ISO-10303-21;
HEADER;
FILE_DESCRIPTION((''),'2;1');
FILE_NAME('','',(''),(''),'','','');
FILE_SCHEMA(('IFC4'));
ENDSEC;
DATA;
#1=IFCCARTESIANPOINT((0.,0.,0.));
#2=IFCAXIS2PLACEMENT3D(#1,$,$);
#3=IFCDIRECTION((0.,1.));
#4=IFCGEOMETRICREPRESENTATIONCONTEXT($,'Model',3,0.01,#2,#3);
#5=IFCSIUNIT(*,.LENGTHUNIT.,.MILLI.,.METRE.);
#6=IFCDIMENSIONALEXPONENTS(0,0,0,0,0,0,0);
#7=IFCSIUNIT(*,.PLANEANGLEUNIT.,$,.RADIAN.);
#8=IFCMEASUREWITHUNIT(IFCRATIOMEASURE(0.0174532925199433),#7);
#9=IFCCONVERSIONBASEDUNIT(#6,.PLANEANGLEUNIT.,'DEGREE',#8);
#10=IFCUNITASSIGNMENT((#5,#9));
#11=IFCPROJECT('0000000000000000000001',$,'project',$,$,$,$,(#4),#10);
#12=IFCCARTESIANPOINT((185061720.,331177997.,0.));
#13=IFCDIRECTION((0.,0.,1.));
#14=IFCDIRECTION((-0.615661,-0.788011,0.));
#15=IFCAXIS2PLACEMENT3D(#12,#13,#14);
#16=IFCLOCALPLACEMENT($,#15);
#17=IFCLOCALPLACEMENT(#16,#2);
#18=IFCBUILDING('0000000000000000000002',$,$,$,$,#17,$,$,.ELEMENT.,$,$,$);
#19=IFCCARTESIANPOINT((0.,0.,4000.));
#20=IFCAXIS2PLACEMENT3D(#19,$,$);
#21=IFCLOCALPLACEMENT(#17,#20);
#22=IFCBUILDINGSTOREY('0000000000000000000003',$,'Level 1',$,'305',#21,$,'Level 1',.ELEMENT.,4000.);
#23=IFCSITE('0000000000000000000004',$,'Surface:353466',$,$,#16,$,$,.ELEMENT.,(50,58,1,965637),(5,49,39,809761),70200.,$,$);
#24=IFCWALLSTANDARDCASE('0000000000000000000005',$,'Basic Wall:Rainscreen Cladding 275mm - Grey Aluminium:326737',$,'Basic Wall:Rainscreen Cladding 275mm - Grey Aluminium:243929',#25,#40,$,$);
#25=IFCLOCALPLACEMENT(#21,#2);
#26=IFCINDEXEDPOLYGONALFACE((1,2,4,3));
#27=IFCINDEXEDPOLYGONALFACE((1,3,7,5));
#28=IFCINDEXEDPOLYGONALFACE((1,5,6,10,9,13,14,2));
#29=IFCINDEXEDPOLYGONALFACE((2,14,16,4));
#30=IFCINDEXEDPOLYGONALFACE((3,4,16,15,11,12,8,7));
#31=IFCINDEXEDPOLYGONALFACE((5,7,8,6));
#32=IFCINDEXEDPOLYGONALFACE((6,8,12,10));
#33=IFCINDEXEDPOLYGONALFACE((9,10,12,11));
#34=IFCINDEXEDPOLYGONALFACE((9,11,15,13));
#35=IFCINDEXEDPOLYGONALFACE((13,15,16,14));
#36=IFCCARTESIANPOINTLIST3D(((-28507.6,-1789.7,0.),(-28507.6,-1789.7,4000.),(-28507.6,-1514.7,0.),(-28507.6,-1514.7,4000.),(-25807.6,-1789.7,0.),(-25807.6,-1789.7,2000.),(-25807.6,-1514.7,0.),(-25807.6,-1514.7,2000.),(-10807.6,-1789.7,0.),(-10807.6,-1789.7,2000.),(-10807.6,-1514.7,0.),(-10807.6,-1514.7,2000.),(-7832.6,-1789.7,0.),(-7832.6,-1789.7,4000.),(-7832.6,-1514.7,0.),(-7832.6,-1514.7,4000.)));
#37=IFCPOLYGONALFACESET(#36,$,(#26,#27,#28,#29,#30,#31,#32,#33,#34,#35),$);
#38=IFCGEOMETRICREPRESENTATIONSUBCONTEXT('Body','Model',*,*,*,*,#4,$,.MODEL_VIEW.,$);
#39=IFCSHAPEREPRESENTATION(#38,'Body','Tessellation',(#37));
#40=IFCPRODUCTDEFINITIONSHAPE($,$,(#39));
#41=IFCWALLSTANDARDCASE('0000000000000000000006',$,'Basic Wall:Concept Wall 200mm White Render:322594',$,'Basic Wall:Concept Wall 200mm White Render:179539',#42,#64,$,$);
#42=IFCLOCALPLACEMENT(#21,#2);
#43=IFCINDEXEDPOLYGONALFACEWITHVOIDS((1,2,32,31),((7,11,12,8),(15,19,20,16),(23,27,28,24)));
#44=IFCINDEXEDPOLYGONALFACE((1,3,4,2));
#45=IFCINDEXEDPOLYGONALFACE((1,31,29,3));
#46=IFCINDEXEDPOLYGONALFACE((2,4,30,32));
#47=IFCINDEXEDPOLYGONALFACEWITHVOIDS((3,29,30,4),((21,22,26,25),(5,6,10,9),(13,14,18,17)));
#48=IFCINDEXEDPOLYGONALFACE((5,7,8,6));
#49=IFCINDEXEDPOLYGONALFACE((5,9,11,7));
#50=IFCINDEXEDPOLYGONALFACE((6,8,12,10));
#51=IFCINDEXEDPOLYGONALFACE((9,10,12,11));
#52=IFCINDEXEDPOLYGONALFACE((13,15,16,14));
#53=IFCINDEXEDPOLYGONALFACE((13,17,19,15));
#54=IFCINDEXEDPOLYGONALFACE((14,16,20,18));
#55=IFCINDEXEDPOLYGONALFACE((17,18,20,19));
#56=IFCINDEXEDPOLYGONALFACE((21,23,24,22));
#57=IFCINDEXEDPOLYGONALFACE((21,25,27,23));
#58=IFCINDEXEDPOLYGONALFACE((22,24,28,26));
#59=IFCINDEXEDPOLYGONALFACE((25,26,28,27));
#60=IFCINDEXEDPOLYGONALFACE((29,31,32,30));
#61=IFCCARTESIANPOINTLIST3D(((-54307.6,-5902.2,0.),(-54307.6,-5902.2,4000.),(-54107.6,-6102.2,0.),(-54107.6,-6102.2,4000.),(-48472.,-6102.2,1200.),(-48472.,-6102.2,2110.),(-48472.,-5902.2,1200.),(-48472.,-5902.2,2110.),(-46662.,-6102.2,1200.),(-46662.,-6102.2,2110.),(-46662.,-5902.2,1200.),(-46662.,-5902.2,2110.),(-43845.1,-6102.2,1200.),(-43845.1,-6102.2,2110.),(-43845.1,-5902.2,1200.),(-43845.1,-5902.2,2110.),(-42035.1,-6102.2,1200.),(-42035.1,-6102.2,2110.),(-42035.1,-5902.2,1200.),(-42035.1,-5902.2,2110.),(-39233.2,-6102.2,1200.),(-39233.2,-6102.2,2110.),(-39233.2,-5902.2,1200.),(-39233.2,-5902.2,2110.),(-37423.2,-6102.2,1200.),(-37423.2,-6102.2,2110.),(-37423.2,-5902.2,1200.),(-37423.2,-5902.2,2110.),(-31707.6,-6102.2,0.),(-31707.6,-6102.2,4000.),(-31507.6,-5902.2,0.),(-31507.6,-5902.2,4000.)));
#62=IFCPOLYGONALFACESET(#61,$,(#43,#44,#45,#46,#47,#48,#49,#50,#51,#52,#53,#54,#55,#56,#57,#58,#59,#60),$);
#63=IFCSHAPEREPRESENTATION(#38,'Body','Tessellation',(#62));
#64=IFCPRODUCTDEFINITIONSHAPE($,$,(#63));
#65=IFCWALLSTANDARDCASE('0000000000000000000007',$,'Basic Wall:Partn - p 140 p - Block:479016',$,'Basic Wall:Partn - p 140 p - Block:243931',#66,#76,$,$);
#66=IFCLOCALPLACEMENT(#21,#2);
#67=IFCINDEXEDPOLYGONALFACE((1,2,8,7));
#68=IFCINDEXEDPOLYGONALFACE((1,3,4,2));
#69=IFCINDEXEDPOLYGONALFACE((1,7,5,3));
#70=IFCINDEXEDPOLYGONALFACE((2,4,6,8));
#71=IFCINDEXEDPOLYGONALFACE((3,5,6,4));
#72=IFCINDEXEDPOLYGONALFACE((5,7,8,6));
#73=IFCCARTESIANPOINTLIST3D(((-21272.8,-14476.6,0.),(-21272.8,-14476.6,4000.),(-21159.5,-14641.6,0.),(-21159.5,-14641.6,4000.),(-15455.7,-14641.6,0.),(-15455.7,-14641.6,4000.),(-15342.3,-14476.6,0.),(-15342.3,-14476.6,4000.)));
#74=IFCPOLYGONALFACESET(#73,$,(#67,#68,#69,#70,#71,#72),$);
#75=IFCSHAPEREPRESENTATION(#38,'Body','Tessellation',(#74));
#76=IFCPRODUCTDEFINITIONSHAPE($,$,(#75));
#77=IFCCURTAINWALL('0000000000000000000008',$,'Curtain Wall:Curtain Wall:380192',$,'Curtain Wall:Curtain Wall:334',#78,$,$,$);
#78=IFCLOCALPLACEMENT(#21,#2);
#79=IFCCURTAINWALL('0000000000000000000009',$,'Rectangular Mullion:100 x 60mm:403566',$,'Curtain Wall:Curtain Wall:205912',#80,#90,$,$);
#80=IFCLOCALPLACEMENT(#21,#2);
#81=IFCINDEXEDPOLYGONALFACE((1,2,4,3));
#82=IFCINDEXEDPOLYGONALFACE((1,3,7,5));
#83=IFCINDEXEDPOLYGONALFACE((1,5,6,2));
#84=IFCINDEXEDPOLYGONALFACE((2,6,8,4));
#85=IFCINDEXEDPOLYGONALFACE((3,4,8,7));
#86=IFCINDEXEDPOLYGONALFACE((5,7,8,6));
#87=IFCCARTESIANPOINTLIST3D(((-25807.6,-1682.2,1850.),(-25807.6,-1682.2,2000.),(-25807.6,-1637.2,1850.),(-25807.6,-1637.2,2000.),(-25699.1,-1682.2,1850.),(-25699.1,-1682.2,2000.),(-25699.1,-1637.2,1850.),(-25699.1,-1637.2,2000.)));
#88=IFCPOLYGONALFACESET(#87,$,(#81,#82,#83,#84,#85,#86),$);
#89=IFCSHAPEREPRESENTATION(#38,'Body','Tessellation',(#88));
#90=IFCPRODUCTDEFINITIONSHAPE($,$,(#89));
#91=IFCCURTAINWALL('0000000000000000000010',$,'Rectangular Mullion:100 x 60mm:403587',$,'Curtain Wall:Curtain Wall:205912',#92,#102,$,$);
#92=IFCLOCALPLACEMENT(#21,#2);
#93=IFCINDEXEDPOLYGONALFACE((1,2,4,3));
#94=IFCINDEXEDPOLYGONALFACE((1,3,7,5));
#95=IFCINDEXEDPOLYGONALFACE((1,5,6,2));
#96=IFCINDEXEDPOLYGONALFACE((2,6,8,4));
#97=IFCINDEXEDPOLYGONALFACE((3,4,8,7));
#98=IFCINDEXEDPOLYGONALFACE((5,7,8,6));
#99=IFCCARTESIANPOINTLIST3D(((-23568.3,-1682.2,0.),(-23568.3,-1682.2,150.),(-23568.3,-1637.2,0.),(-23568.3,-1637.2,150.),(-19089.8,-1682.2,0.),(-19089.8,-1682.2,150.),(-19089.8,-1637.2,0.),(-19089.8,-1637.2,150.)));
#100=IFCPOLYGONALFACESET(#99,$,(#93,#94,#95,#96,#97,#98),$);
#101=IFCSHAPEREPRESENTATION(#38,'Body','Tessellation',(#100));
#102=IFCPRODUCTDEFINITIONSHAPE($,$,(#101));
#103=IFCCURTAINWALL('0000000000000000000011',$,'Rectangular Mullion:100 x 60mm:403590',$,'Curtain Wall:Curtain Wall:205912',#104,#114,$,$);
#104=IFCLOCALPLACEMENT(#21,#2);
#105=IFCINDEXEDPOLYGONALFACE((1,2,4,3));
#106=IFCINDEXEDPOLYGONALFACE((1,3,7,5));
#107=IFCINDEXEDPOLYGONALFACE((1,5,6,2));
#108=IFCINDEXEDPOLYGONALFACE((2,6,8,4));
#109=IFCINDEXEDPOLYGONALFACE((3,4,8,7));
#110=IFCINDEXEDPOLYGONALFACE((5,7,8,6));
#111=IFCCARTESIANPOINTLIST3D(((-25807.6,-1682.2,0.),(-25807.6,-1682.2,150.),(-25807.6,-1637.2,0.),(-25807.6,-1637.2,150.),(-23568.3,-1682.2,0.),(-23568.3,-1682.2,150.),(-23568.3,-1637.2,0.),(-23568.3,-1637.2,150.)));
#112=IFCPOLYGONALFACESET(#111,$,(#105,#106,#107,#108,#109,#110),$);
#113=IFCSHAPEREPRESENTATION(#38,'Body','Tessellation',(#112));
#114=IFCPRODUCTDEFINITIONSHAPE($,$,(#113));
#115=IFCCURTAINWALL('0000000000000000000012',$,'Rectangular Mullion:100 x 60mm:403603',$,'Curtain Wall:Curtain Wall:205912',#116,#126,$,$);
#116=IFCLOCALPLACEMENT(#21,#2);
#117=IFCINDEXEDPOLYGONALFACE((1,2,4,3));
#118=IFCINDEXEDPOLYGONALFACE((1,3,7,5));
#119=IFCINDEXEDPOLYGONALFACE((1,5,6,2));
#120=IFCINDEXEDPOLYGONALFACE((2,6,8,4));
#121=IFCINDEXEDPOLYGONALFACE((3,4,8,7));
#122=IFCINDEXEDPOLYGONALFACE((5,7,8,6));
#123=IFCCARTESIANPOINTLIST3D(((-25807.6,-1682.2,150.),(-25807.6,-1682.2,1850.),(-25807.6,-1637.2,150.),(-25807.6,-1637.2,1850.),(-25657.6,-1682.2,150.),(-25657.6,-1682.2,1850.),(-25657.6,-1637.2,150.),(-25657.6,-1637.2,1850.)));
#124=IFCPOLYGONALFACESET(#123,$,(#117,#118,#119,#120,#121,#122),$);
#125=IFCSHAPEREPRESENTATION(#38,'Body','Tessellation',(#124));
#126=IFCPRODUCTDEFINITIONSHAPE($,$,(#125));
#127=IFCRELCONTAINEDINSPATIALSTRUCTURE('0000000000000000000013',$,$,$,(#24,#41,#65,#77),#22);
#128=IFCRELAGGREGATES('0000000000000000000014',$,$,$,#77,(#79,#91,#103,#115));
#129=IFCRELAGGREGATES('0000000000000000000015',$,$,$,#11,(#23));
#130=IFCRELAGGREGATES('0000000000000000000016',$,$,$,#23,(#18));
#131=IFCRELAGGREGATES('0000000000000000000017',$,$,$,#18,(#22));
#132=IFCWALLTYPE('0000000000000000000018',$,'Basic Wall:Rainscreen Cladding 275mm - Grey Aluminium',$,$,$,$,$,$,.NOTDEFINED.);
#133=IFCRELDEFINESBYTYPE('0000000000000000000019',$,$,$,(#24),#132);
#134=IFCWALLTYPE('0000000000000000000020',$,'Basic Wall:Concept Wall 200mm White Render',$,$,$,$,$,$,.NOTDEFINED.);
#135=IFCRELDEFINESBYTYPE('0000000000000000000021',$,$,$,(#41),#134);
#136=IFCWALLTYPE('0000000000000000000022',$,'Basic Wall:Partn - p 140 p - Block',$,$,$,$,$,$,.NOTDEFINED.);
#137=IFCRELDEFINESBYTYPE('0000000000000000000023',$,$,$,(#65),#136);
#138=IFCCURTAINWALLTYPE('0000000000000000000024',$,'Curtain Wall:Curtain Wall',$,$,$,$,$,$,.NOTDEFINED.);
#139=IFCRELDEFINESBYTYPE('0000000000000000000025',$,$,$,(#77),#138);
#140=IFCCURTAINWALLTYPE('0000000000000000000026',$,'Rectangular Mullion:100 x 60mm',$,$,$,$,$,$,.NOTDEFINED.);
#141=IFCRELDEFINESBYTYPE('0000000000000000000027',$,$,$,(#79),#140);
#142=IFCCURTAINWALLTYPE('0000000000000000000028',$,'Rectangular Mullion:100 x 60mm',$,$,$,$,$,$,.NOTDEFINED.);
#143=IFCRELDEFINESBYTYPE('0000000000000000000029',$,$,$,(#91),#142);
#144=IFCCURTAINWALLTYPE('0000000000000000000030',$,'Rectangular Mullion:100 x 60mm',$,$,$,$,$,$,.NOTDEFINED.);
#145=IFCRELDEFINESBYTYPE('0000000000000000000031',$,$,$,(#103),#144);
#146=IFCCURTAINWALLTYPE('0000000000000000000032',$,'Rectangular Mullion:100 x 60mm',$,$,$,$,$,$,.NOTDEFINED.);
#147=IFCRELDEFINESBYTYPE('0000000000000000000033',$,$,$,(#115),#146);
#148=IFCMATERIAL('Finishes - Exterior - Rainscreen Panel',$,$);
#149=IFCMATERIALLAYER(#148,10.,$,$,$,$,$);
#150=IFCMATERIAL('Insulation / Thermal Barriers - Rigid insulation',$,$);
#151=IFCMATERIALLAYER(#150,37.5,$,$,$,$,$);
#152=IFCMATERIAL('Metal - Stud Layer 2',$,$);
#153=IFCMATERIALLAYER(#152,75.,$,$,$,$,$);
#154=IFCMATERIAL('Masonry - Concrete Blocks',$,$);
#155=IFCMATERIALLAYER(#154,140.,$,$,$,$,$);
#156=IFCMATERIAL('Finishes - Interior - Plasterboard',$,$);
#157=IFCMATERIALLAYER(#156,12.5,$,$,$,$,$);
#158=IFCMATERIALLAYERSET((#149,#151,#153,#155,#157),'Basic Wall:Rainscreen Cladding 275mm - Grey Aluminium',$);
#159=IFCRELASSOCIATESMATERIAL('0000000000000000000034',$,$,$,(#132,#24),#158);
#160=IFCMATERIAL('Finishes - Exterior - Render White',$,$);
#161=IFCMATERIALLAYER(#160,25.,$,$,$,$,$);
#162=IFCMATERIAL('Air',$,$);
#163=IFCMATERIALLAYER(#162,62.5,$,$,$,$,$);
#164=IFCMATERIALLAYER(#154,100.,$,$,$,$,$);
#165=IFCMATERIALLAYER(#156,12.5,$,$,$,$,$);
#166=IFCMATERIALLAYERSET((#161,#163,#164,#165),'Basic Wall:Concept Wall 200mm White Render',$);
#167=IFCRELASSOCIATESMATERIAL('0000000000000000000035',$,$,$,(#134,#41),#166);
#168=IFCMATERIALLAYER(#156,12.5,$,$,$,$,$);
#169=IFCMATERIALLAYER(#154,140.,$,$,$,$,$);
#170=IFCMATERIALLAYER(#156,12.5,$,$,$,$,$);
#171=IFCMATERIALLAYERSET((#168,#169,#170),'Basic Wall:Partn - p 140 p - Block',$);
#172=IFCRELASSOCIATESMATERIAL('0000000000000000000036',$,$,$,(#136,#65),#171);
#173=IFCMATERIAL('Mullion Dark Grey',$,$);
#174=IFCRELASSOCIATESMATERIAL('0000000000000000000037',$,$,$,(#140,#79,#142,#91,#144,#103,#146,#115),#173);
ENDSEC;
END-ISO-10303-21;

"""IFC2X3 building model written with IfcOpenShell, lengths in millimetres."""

from ifc_helpers import new_model, entity, si_unit, converted_unit, direction, frame, frame_2d, origin, origin_2d_with_axis, place, context, subcontext, project, spatial, polyline, rectangle, outline, extrude, clip, halfspace, source, transform, mapped, material, layer, layer_set, layer_usage, type_object, type_shapes, element, aggregate, save


model = new_model("IFC2X3")

# Units and contexts
model_context = context("Model", 3, precision=0.01, world=origin(), true_north=direction((0.0, 1.0)))
body_context = subcontext(model_context, "Body", "Model", "MODEL_VIEW")
ifc_project = project(units=[si_unit("LENGTHUNIT", "METRE", prefix="MILLI"), converted_unit("PLANEANGLEUNIT", "DEGREE", entity("IfcRatioMeasure", 0.0174532925199433), si_unit("PLANEANGLEUNIT", "RADIAN"), dimensions=[0, 0, 0, 0, 0, 0, 0])], contexts=[model_context])

# Site, building, storey
site_placement = place(None, frame((185061720.0, 331177997.0, 0.0), z_axis=(0.0, 0.0, 1.0), x_axis=(-0.615661, -0.788011, 0.0)))
site = spatial("IfcSite", under=ifc_project, at=site_placement, Name="Surface:353466", CompositionType="ELEMENT", RefLatitude=(50, 58, 1, 965637), RefLongitude=(5, 49, 39, 809761), RefElevation=70200.0)
building_placement = place(site_placement, origin())
building = spatial("IfcBuilding", under=site, at=building_placement, CompositionType="ELEMENT")
storey_placement = place(building_placement, frame((0.0, 0.0, 4000.0)))
storey = spatial("IfcBuildingStorey", under=building, at=storey_placement, Name="Level 1", ObjectType="305", LongName="Level 1", CompositionType="ELEMENT", Elevation=4000.0)

# Wall, opening
ifc_material_1 = material(Name="Finishes - Exterior - Rainscreen Panel")
ifc_layer_1 = layer(ifc_material_1, 10.0)
ifc_material_2 = material(Name="Insulation / Thermal Barriers - Rigid insulation")
ifc_layer_2 = layer(ifc_material_2, 37.5)
ifc_material_3 = material(Name="Metal - Stud Layer 2")
ifc_layer_3 = layer(ifc_material_3, 75.0)
ifc_material_4 = material(Name="Masonry - Concrete Blocks")
ifc_layer_4 = layer(ifc_material_4, 140.0)
ifc_material_5 = material(Name="Finishes - Interior - Plasterboard")
ifc_layer_5 = layer(ifc_material_5, 12.5)
ifc_layer_set_1 = layer_set([ifc_layer_1, ifc_layer_2, ifc_layer_3, ifc_layer_4, ifc_layer_5], Name="Basic Wall:Rainscreen Cladding 275mm - Grey Aluminium")
ifc_layer_usage_1 = layer_usage(ifc_layer_set_1, "AXIS2", "NEGATIVE", 137.5)
wall_type_1 = type_object("IfcWallType", Name="Basic Wall:Rainscreen Cladding 275mm - Grey Aluminium", PredefinedType="NOTDEFINED", material=ifc_layer_set_1)
wall_1_placement = place(storey_placement, frame((-28507.6, -1652.2, 0.0)))
wall_1 = element("IfcWallStandardCase", 1, at=wall_1_placement, inside=storey, type_object=wall_type_1, material=ifc_layer_usage_1, Name="Basic Wall:Rainscreen Cladding 275mm - Grey Aluminium:326737", ObjectType="Basic Wall:Rainscreen Cladding 275mm - Grey Aluminium:243929", context=body_context, shape_type="Clipping", body=[
    clip(extrude(rectangle(XDim=20675.0, YDim=275.0, at=frame_2d((10337.5, 0.0), x_axis=(-1.0, 0.0))), origin(), (0.0, 0.0, 1.0), 4000.0), halfspace(frame((0.0, 0.0, -4000.0)), True)),
])
opening_1_placement = place(wall_1_placement, origin())
element("IfcOpeningElement", 2, at=opening_1_placement, cuts=wall_1, ObjectType="Opening", context=body_context, shape_type="SweptSolid", body=[
    extrude(rectangle(XDim=2000.0, YDim=15000.0, at=origin_2d_with_axis()), frame((10200.0, -289.9, 1000.0), z_axis=(0.0, 1.0, 0.0), x_axis=(0.0, 0.0, 1.0)), (0.0, 0.0, 1.0), 579.8),
])

# Wall, openings
ifc_material_6 = material(Name="Finishes - Exterior - Render White")
ifc_layer_6 = layer(ifc_material_6, 25.0)
ifc_material_7 = material(Name="Air")
ifc_layer_7 = layer(ifc_material_7, 62.5)
ifc_layer_8 = layer(ifc_material_4, 100.0)
ifc_layer_9 = layer(ifc_material_5, 12.5)
ifc_layer_set_2 = layer_set([ifc_layer_6, ifc_layer_7, ifc_layer_8, ifc_layer_9], Name="Basic Wall:Concept Wall 200mm White Render")
ifc_layer_usage_2 = layer_usage(ifc_layer_set_2, "AXIS2", "POSITIVE", -100.0)
wall_type_2 = type_object("IfcWallType", Name="Basic Wall:Concept Wall 200mm White Render", PredefinedType="NOTDEFINED", material=ifc_layer_set_2)
wall_2_placement = place(storey_placement, frame((-31507.6, -6002.2, 0.0), z_axis=(0.0, 0.0, 1.0), x_axis=(-1.0, 0.0, 0.0)))
wall_2 = element("IfcWallStandardCase", 3, at=wall_2_placement, inside=storey, type_object=wall_type_2, material=ifc_layer_usage_2, Name="Basic Wall:Concept Wall 200mm White Render:322594", ObjectType="Basic Wall:Concept Wall 200mm White Render:179539", context=body_context, shape_type="Clipping", body=[
    clip(extrude(outline(polyline([(22800.0, -100.0), (22600.0, 100.0), (13722.5, 100.0), (13557.5, 100.0), (5162.5, 100.0), (4997.5, 100.0), (200.0, 100.0), (0.0, -100.0), (22800.0, -100.0)])), origin(), (0.0, 0.0, 1.0), 4000.0), halfspace(frame((0.0, 0.0, -4000.0)), True)),
])
opening_2_placement = place(wall_2_placement, origin())
element("IfcOpeningElement", 4, at=opening_2_placement, cuts=wall_2, ObjectType="Opening", context=body_context, shape_type="SweptSolid", body=[
    extrude(rectangle(XDim=910.0, YDim=1810.0, at=frame_2d((0.0, 0.0), x_axis=(1.0, 0.0))), frame((11432.5, -1424.0, 1655.0), z_axis=(0.0, 1.0, 0.0), x_axis=(0.0, 0.0, -1.0)), (0.0, 0.0, 1.0), 3048.0),
])
opening_3_placement = place(wall_2_placement, origin())
element("IfcOpeningElement", 5, at=opening_3_placement, cuts=wall_2, ObjectType="Opening", context=body_context, shape_type="SweptSolid", body=[
    extrude(rectangle(XDim=910.0, YDim=1810.0, at=frame_2d((0.0, 0.0), x_axis=(1.0, 0.0))), frame((16059.4, -1424.0, 1655.0), z_axis=(0.0, 1.0, 0.0), x_axis=(0.0, 0.0, -1.0)), (0.0, 0.0, 1.0), 3048.0),
])
opening_4_placement = place(wall_2_placement, origin())
element("IfcOpeningElement", 6, at=opening_4_placement, cuts=wall_2, ObjectType="Opening", context=body_context, shape_type="SweptSolid", body=[
    extrude(rectangle(XDim=910.0, YDim=1810.0, at=frame_2d((0.0, 0.0), x_axis=(1.0, 0.0))), frame((6820.6, -1424.0, 1655.0), z_axis=(0.0, 1.0, 0.0), x_axis=(0.0, 0.0, -1.0)), (0.0, 0.0, 1.0), 3048.0),
])
opening_5_placement = place(wall_2_placement, frame((12337.5, 100.0, 1200.0)))
element("IfcOpeningElement", 7, at=opening_5_placement, cuts=wall_2, ObjectType="Opening", context=body_context, shape_type="SweptSolid", body=[
    extrude(rectangle(XDim=910.0, YDim=1810.0, at=frame_2d((455.0, 905.0), x_axis=(-1.0, 0.0))), frame((0.0, 0.0, 0.0), z_axis=(0.0, -1.0, 0.0), x_axis=(0.0, 0.0, 1.0)), (0.0, 0.0, 1.0), 200.0),
])
opening_6_placement = place(wall_2_placement, frame((16964.4, 100.0, 1200.0)))
element("IfcOpeningElement", 8, at=opening_6_placement, cuts=wall_2, ObjectType="Opening", context=body_context, shape_type="SweptSolid", body=[
    extrude(rectangle(XDim=910.0, YDim=1810.0, at=frame_2d((455.0, 905.0), x_axis=(-1.0, 0.0))), frame((0.0, 0.0, 0.0), z_axis=(0.0, -1.0, 0.0), x_axis=(0.0, 0.0, 1.0)), (0.0, 0.0, 1.0), 200.0),
])
opening_7_placement = place(wall_2_placement, frame((7725.6, 100.0, 1200.0)))
element("IfcOpeningElement", 9, at=opening_7_placement, cuts=wall_2, ObjectType="Opening", context=body_context, shape_type="SweptSolid", body=[
    extrude(rectangle(XDim=910.0, YDim=1810.0, at=frame_2d((455.0, 905.0), x_axis=(-1.0, 0.0))), frame((0.0, 0.0, 0.0), z_axis=(0.0, -1.0, 0.0), x_axis=(0.0, 0.0, 1.0)), (0.0, 0.0, 1.0), 200.0),
])

# Wall
ifc_layer_10 = layer(ifc_material_5, 12.5)
ifc_layer_11 = layer(ifc_material_4, 140.0)
ifc_layer_12 = layer(ifc_material_5, 12.5)
ifc_layer_set_3 = layer_set([ifc_layer_10, ifc_layer_11, ifc_layer_12], Name="Basic Wall:Partn - p 140 p - Block")
ifc_layer_usage_3 = layer_usage(ifc_layer_set_3, "AXIS2", "NEGATIVE", 82.5)
wall_type_3 = type_object("IfcWallType", Name="Basic Wall:Partn - p 140 p - Block", PredefinedType="NOTDEFINED", material=ifc_layer_set_3)
wall_3_placement = place(storey_placement, frame((-21272.8, -14559.1, 0.0)))
element("IfcWallStandardCase", 10, at=wall_3_placement, inside=storey, type_object=wall_type_3, material=ifc_layer_usage_3, Name="Basic Wall:Partn - p 140 p - Block:479016", ObjectType="Basic Wall:Partn - p 140 p - Block:243931", context=body_context, shape_type="Clipping", body=[
    clip(extrude(outline(polyline([(5817.2, -82.5), (5930.5, 82.5), (5778.8, 82.5), (3047.7, 82.5), (2882.7, 82.5), (151.6, 82.5), (0.0, 82.5), (113.3, -82.5), (5817.2, -82.5)])), origin(), (0.0, 0.0, 1.0), 4000.0), halfspace(origin(), True)),
])

# Curtain walls
curtain_wall_type_1 = type_object("IfcCurtainWallType", Name="Curtain Wall:Curtain Wall", PredefinedType="NOTDEFINED")
curtain_wall_1_placement = place(storey_placement, frame((0.0, 0.0, -4000.0)))
curtain_wall_1 = element("IfcCurtainWall", 11, at=curtain_wall_1_placement, inside=storey, type_object=curtain_wall_type_1, Name="Curtain Wall:Curtain Wall:380192", ObjectType="Curtain Wall:Curtain Wall:334")
ifc_material_8 = material(Name="Mullion Dark Grey")
curtain_wall_type_2 = type_object("IfcCurtainWallType", Name="Rectangular Mullion:100 x 60mm", PredefinedType="NOTDEFINED", material=ifc_material_8)
shared_shape_1 = source(origin(), body_context, "Body", "SweptSolid", [
    extrude(rectangle(XDim=45.0, YDim=150.0, at=frame_2d((0.0, 0.0), x_axis=(1.0, 0.0))), frame((-75.0, 7.5, -108.5), z_axis=(0.0, 0.0, 1.0), x_axis=(0.0, -1.0, 0.0)), (0.0, 0.0, 1.0), 108.5),
])
type_shapes(curtain_wall_type_2, [shared_shape_1])
curtain_wall_2_placement = place(storey_placement, frame((-25699.1, -1652.2, 2000.0), z_axis=(1.0, 0.0, 0.0), x_axis=(0.0, 0.0, 1.0)))
curtain_wall_2 = element("IfcCurtainWall", 12, at=curtain_wall_2_placement, type_object=curtain_wall_type_2, material=ifc_material_8, Name="Rectangular Mullion:100 x 60mm:403566", ObjectType="Curtain Wall:Curtain Wall:205912", context=body_context, shape_type="MappedRepresentation", body=[
    mapped(shared_shape_1, transform((0.0, 0.0, 0.0), scale=1.0)),
])
curtain_wall_type_3 = type_object("IfcCurtainWallType", Name="Rectangular Mullion:100 x 60mm", PredefinedType="NOTDEFINED", material=ifc_material_8)
shared_shape_2 = source(origin(), body_context, "Body", "SweptSolid", [
    extrude(rectangle(XDim=150.0, YDim=45.0, at=frame_2d((0.0, 0.0), x_axis=(1.0, 0.0))), frame((-75.0, 7.5, -4478.5), z_axis=(0.0, 0.0, 1.0), x_axis=(-1.0, 0.0, 0.0)), (0.0, 0.0, 1.0), 4478.5),
])
type_shapes(curtain_wall_type_3, [shared_shape_2])
curtain_wall_3_placement = place(storey_placement, frame((-23568.3, -1652.2, 0.0), z_axis=(-1.0, 0.0, 0.0), x_axis=(0.0, 0.0, -1.0)))
curtain_wall_3 = element("IfcCurtainWall", 13, at=curtain_wall_3_placement, type_object=curtain_wall_type_3, material=ifc_material_8, Name="Rectangular Mullion:100 x 60mm:403587", ObjectType="Curtain Wall:Curtain Wall:205912", context=body_context, shape_type="MappedRepresentation", body=[
    mapped(shared_shape_2, transform((0.0, 0.0, 0.0), scale=1.0)),
])
curtain_wall_type_4 = type_object("IfcCurtainWallType", Name="Rectangular Mullion:100 x 60mm", PredefinedType="NOTDEFINED", material=ifc_material_8)
shared_shape_3 = source(origin(), body_context, "Body", "SweptSolid", [
    extrude(rectangle(XDim=150.0, YDim=45.0, at=frame_2d((0.0, 0.0), x_axis=(1.0, 0.0))), frame((-75.0, 7.5, -2239.3), z_axis=(0.0, 0.0, 1.0), x_axis=(-1.0, 0.0, 0.0)), (0.0, 0.0, 1.0), 2239.3),
])
type_shapes(curtain_wall_type_4, [shared_shape_3])
curtain_wall_4_placement = place(storey_placement, frame((-25807.6, -1652.2, 0.0), z_axis=(-1.0, 0.0, 0.0), x_axis=(0.0, 0.0, -1.0)))
curtain_wall_4 = element("IfcCurtainWall", 14, at=curtain_wall_4_placement, type_object=curtain_wall_type_4, material=ifc_material_8, Name="Rectangular Mullion:100 x 60mm:403590", ObjectType="Curtain Wall:Curtain Wall:205912", context=body_context, shape_type="MappedRepresentation", body=[
    mapped(shared_shape_3, transform((0.0, 0.0, 0.0), scale=1.0)),
])
curtain_wall_type_5 = type_object("IfcCurtainWallType", Name="Rectangular Mullion:100 x 60mm", PredefinedType="NOTDEFINED", material=ifc_material_8)
shared_shape_4 = source(origin(), body_context, "Body", "SweptSolid", [
    extrude(rectangle(XDim=150.0, YDim=45.0, at=frame_2d((0.0, 0.0), x_axis=(1.0, 0.0))), frame((-75.0, 7.5, -1700.0), z_axis=(0.0, 0.0, 1.0), x_axis=(-1.0, 0.0, 0.0)), (0.0, 0.0, 1.0), 1700.0),
])
type_shapes(curtain_wall_type_5, [shared_shape_4])
curtain_wall_5_placement = place(storey_placement, frame((-25807.6, -1652.2, 1850.0), z_axis=(0.0, 0.0, 1.0), x_axis=(-1.0, 0.0, 0.0)))
curtain_wall_5 = element("IfcCurtainWall", 15, at=curtain_wall_5_placement, type_object=curtain_wall_type_5, material=ifc_material_8, Name="Rectangular Mullion:100 x 60mm:403603", ObjectType="Curtain Wall:Curtain Wall:205912", context=body_context, shape_type="MappedRepresentation", body=[
    mapped(shared_shape_4, transform((0.0, 0.0, 0.0), scale=1.0)),
])
aggregate(curtain_wall_1, [curtain_wall_2, curtain_wall_3, curtain_wall_4, curtain_wall_5])

save(model, "model.ifc")
